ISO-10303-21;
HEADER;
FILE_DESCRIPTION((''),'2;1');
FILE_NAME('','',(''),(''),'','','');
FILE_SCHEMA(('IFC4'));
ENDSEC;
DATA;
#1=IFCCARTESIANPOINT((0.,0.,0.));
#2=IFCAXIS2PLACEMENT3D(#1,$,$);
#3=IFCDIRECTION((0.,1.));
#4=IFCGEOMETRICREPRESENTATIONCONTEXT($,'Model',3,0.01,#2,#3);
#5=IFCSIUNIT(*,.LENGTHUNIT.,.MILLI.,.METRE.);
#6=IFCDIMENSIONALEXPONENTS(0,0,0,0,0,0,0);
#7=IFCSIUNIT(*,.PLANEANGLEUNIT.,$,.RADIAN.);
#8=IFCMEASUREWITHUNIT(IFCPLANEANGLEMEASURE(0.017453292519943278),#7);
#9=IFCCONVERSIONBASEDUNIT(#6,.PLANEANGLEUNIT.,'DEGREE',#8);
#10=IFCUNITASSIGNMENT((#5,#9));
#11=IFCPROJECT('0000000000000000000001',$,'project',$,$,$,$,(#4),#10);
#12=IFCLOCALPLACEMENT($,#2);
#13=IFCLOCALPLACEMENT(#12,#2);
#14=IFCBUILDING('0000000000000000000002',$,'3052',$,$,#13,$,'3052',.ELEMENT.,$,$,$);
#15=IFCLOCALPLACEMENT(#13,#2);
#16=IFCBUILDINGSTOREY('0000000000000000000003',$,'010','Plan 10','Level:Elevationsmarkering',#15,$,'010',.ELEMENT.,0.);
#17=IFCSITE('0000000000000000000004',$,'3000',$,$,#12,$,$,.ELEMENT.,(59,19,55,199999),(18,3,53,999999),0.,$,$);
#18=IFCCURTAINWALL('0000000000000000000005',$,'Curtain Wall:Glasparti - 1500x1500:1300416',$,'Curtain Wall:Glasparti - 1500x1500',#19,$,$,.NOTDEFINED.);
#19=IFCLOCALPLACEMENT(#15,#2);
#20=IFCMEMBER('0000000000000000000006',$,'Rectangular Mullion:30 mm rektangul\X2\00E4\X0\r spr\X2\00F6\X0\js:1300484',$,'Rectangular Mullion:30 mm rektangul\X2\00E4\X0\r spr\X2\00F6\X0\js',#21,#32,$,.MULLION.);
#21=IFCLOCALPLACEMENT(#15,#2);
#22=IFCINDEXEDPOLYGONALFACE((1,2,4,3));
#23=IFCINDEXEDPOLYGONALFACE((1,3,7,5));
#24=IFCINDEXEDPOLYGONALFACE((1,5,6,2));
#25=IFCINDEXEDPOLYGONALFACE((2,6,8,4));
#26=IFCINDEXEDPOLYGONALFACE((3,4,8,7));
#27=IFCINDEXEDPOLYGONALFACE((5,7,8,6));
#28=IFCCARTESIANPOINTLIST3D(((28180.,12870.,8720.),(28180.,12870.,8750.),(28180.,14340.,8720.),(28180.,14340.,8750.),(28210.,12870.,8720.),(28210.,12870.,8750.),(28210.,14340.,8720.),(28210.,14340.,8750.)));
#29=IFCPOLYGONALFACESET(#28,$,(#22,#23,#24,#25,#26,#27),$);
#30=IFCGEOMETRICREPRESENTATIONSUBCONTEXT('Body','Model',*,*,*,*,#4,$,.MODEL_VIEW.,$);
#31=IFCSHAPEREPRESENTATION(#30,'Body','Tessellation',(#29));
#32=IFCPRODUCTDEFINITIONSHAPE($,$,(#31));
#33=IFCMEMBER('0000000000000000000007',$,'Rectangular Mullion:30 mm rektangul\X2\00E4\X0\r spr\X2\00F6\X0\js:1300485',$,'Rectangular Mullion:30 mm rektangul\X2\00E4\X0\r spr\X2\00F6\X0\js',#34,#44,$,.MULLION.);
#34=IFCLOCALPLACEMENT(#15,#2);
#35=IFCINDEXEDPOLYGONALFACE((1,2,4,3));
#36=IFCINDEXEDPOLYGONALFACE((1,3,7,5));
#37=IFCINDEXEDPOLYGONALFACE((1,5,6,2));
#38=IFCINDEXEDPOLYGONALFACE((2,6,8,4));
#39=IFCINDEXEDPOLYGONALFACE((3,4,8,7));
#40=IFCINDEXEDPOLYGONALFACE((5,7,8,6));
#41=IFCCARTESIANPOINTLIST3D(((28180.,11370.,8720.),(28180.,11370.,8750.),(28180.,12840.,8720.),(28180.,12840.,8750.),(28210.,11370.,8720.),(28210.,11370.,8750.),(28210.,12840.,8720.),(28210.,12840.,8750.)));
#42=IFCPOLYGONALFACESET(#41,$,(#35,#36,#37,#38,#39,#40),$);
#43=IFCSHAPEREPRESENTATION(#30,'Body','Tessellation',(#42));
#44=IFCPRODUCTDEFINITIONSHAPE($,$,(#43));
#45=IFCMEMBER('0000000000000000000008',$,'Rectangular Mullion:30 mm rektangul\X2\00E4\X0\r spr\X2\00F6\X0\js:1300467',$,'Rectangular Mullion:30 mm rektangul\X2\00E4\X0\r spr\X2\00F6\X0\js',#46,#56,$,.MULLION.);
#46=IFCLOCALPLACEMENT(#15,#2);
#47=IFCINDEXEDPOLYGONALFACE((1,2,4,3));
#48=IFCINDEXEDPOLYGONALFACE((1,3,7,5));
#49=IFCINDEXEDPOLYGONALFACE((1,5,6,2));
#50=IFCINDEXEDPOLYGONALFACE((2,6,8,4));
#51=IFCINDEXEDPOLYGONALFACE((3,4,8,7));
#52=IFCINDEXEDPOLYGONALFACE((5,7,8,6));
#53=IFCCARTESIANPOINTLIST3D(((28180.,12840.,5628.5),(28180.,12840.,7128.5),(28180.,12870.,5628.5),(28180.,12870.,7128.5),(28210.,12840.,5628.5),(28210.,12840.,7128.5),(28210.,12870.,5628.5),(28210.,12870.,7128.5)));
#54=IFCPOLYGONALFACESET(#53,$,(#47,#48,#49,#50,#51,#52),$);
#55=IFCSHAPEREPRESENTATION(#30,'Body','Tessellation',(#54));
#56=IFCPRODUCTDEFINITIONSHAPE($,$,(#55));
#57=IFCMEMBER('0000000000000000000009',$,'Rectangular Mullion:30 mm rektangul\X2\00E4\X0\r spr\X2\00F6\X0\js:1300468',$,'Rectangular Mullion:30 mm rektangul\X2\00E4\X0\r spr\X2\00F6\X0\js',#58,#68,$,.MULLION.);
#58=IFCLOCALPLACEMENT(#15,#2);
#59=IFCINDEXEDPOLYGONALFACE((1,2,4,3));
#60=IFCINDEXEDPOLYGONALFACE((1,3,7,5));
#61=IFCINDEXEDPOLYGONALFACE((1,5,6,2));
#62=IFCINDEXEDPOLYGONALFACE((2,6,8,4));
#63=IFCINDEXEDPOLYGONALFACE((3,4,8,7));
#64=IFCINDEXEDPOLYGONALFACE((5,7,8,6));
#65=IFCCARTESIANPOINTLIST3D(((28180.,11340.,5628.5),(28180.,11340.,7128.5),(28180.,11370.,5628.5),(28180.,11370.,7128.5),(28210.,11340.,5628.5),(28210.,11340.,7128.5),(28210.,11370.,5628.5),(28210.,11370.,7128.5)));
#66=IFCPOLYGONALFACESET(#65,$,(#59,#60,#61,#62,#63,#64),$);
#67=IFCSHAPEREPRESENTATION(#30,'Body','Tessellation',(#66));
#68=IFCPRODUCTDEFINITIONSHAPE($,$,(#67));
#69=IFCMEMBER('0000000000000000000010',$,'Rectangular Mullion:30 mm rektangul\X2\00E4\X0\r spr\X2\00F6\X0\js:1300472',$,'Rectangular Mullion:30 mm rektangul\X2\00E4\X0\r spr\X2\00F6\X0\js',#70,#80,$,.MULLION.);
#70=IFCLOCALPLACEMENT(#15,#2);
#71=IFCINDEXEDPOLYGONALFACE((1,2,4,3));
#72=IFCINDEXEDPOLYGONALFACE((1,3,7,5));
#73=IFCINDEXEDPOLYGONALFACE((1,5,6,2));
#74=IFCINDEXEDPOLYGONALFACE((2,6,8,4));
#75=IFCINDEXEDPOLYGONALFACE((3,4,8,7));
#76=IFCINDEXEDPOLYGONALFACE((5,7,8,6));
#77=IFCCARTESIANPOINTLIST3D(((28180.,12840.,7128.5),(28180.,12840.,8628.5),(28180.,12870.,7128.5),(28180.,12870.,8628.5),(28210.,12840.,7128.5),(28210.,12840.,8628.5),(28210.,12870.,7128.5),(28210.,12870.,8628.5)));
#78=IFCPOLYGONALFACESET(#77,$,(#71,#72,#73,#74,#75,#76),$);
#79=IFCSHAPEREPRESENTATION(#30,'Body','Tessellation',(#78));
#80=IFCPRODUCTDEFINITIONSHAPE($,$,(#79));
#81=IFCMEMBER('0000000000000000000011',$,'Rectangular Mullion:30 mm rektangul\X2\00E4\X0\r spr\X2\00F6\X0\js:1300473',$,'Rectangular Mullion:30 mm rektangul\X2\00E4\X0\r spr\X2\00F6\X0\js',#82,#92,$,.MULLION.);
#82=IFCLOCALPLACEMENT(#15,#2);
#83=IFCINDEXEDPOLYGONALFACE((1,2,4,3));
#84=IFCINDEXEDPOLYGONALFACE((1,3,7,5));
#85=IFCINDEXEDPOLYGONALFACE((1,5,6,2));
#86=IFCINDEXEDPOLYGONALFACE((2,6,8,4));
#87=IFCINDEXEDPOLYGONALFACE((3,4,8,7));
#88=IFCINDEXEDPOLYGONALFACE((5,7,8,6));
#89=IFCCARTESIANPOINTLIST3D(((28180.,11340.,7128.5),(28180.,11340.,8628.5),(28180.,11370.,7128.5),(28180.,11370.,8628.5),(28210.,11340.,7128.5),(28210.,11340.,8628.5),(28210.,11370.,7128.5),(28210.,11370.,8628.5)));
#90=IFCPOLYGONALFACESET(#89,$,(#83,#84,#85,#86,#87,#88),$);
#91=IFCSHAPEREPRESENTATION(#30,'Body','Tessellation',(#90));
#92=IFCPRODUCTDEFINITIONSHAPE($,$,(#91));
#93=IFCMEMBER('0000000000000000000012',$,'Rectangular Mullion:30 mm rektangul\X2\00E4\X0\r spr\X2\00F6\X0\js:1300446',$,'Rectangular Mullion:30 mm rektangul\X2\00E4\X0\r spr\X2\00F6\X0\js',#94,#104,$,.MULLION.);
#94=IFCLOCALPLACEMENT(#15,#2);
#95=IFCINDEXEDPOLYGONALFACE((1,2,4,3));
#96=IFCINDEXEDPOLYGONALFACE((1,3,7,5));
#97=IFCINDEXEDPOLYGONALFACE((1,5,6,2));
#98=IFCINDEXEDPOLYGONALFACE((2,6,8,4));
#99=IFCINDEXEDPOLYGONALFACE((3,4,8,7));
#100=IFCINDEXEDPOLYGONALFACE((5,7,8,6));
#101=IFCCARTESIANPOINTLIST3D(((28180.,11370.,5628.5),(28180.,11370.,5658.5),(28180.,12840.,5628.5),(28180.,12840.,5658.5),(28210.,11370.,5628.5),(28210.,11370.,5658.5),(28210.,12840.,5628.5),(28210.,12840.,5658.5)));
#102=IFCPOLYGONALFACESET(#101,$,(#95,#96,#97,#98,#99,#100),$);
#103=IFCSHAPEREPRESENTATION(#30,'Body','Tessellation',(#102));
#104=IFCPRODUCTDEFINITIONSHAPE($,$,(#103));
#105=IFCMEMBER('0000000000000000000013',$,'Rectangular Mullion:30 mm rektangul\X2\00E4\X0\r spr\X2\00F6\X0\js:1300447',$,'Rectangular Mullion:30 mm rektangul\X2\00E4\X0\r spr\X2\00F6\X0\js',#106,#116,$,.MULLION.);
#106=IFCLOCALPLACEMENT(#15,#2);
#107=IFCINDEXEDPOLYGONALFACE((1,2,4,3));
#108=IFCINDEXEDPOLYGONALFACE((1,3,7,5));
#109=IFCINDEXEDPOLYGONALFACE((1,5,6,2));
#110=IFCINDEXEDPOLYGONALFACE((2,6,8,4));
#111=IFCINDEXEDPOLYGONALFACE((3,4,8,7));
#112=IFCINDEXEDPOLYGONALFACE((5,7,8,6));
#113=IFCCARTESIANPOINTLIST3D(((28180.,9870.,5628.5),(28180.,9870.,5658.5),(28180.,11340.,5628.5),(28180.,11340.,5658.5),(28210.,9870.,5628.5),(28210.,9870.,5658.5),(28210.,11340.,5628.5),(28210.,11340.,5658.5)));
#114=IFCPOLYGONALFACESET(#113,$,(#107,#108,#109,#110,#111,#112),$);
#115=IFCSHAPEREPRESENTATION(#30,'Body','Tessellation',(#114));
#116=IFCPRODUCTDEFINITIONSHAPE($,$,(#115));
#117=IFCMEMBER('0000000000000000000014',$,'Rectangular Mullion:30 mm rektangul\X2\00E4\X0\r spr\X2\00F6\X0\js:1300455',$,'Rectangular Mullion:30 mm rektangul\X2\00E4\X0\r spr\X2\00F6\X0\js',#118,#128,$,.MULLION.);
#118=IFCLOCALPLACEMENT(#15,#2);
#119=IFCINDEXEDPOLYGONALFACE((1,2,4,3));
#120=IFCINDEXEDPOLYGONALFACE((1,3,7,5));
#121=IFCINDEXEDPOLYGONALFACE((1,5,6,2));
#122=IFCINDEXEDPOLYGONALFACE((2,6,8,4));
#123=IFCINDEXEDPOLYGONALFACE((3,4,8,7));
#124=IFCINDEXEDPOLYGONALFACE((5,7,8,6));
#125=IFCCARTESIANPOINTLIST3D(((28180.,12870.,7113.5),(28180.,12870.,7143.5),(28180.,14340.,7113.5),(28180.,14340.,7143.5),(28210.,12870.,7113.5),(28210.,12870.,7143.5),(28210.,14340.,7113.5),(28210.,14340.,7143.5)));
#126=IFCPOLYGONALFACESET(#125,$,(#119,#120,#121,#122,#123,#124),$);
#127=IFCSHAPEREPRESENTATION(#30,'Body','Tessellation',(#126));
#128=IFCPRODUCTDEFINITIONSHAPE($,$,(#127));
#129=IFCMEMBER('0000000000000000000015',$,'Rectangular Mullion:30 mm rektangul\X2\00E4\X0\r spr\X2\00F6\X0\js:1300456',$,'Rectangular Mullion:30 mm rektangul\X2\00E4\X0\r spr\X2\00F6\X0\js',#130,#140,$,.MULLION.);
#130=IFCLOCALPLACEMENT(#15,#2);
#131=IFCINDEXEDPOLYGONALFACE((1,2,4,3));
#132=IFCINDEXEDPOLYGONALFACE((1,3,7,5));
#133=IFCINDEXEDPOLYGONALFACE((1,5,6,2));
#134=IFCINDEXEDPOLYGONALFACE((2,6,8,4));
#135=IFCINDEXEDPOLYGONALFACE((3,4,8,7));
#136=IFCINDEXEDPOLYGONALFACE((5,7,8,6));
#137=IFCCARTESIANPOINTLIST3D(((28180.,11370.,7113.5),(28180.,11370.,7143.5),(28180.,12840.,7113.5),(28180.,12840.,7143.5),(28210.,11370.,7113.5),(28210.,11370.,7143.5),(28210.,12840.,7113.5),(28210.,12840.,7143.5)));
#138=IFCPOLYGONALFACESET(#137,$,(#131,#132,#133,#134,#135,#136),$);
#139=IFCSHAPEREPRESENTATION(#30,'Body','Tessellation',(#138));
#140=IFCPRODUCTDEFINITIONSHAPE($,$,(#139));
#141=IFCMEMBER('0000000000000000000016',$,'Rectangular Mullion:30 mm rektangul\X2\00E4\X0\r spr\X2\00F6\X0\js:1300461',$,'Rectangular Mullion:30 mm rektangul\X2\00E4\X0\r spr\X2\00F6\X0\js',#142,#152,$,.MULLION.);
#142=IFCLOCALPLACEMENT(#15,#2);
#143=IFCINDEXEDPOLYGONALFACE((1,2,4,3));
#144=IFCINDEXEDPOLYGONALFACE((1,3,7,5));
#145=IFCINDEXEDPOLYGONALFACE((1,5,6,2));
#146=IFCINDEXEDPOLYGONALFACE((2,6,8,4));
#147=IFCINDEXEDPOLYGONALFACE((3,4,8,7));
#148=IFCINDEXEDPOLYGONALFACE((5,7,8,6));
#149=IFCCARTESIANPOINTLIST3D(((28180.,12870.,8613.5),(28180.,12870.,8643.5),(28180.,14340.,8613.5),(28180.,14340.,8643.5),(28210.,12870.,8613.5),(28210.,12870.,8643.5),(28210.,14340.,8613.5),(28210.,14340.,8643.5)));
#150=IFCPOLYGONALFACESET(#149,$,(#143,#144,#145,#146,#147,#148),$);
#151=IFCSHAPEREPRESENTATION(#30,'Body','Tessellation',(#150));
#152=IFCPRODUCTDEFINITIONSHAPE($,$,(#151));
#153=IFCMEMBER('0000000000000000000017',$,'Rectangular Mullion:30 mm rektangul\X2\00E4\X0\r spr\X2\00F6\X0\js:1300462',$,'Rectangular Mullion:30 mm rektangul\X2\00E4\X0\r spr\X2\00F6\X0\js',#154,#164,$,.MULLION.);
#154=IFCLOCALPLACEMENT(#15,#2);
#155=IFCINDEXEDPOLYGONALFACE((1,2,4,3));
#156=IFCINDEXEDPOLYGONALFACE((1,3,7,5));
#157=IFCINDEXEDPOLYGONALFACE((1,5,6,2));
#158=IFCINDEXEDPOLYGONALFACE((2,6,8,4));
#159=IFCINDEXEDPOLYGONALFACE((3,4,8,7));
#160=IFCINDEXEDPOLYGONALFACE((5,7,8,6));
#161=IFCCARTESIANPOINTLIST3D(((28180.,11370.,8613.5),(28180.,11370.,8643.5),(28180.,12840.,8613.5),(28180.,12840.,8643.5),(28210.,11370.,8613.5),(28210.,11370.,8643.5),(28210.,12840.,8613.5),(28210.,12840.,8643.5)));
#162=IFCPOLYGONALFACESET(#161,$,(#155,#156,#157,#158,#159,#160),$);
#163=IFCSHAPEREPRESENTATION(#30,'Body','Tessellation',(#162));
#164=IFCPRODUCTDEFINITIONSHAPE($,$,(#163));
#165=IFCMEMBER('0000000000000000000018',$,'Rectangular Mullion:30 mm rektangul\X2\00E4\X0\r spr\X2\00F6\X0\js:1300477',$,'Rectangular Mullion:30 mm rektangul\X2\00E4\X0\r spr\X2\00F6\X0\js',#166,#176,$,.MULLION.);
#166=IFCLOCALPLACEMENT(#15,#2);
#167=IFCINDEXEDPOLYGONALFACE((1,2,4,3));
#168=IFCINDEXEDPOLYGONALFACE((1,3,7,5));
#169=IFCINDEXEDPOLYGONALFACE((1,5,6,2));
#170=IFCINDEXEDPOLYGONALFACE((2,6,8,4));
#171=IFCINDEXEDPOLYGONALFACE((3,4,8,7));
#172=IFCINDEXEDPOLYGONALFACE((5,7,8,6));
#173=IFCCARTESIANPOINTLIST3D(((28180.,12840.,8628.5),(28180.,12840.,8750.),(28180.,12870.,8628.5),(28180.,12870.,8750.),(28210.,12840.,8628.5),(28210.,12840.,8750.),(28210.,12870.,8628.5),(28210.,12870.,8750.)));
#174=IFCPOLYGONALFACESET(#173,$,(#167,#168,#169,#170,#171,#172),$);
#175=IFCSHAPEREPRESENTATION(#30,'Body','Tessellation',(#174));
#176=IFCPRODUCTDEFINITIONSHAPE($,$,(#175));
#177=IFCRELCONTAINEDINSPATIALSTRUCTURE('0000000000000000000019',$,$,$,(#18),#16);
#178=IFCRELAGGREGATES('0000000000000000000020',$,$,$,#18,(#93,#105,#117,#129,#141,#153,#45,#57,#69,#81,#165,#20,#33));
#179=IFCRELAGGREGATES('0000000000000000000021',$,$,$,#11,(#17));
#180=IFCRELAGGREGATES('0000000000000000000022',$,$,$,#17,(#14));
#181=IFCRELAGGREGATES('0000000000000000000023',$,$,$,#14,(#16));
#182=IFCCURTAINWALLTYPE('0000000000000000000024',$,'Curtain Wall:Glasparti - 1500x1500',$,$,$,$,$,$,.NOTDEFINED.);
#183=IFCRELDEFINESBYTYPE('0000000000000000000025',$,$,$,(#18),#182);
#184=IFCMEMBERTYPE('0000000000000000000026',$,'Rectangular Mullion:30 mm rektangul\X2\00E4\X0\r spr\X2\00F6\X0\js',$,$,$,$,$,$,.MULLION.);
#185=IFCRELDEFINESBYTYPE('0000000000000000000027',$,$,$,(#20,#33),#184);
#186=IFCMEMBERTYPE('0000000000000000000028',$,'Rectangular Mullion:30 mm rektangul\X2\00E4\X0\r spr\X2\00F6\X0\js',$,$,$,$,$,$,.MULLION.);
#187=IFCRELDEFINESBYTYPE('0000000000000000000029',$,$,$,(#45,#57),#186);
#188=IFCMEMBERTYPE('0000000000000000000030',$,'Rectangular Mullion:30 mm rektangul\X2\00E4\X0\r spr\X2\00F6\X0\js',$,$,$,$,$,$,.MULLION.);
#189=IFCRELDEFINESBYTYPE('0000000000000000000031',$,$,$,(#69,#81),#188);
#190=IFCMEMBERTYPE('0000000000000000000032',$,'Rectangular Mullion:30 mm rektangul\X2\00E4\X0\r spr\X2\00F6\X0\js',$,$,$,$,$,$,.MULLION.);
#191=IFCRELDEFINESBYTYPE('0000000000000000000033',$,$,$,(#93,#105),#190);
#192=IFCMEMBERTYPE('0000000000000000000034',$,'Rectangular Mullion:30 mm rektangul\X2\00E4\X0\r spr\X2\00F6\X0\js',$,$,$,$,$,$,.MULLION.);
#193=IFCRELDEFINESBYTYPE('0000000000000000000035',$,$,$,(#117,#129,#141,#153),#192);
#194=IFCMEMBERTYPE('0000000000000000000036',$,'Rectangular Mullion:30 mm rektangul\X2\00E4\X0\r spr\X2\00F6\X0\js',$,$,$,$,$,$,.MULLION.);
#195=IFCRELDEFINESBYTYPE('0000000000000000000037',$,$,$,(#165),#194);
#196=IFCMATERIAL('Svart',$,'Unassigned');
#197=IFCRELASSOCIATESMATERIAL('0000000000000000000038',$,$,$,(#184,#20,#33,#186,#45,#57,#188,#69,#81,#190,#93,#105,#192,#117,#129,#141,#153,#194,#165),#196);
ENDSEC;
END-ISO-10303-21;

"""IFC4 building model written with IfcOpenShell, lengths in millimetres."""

from ifc_helpers import new_model, entity, si_unit, converted_unit, direction, frame, origin, place, context, subcontext, project, spatial, indexed_curve, outline, extrude, source, transform, mapped, material, type_object, type_shapes, element, aggregate, save


model = new_model("IFC4")

# Units and contexts
model_context = context("Model", 3, precision=0.01, world=origin(), true_north=direction((0.0, 1.0)))
body_context = subcontext(model_context, "Body", "Model", "MODEL_VIEW")
ifc_project = project(units=[si_unit("LENGTHUNIT", "METRE", prefix="MILLI"), converted_unit("PLANEANGLEUNIT", "DEGREE", entity("IfcPlaneAngleMeasure", 0.017453292519943278), si_unit("PLANEANGLEUNIT", "RADIAN"), dimensions=[0, 0, 0, 0, 0, 0, 0])], contexts=[model_context])

# Site, building, storey
site_placement = place(None, origin())
site = spatial("IfcSite", under=ifc_project, at=site_placement, Name="3000", CompositionType="ELEMENT", RefLatitude=(59, 19, 55, 199999), RefLongitude=(18, 3, 53, 999999), RefElevation=0.0)
building_placement = place(site_placement, origin())
building = spatial("IfcBuilding", under=site, at=building_placement, Name="3052", LongName="3052", CompositionType="ELEMENT")
storey_placement = place(building_placement, origin())
storey = spatial("IfcBuildingStorey", under=building, at=storey_placement, Name="010", Description="Plan 10", ObjectType="Level:Elevationsmarkering", LongName="010", CompositionType="ELEMENT", Elevation=0.0)

# Curtain wall, members
curtain_wall_type = type_object("IfcCurtainWallType", Name="Curtain Wall:Glasparti - 1500x1500", PredefinedType="NOTDEFINED")
curtain_wall_placement = place(storey_placement, origin())
curtain_wall = element("IfcCurtainWall", 1, at=curtain_wall_placement, inside=storey, type_object=curtain_wall_type, Name="Curtain Wall:Glasparti - 1500x1500:1300416", ObjectType="Curtain Wall:Glasparti - 1500x1500", PredefinedType="NOTDEFINED")
ifc_material_1 = material(Name="Svart", Category="Unassigned")
member_type_1 = type_object("IfcMemberType", Name="Rectangular Mullion:30 mm rektangulär spröjs", PredefinedType="MULLION", material=ifc_material_1)
shared_shape_1 = source(origin(), body_context, "Body", "SweptSolid", [
    extrude(outline(indexed_curve([(-15.0, -15.0), (15.0, -15.0), (15.0, 15.0), (-15.0, 15.0), (-15.0, -15.0)], self_intersect=False)), frame((-15.0, 0.0, -1470.0), z_axis=(0.0, 0.0, 1.0), x_axis=(-1.0, 0.0, 0.0)), (0.0, 0.0, 1.0), 1470.0),
])
type_shapes(member_type_1, [shared_shape_1])
member_1_placement = place(curtain_wall_placement, frame((28195.0, 12870.0, 8750.0), z_axis=(0.0, -1.0, 0.0), x_axis=(0.0, 0.0, 1.0)))
member_1 = element("IfcMember", 2, at=member_1_placement, type_object=member_type_1, material=ifc_material_1, Name="Rectangular Mullion:30 mm rektangulär spröjs:1300484", ObjectType="Rectangular Mullion:30 mm rektangulär spröjs", PredefinedType="MULLION", context=body_context, shape_type="MappedRepresentation", body=[
    mapped(shared_shape_1, transform((0.0, 0.0, 0.0), scale=1.0)),
])
member_2_placement = place(curtain_wall_placement, frame((28195.0, 11370.0, 8750.0), z_axis=(0.0, -1.0, 0.0), x_axis=(0.0, 0.0, 1.0)))
member_2 = element("IfcMember", 3, at=member_2_placement, type_object=member_type_1, material=ifc_material_1, Name="Rectangular Mullion:30 mm rektangulär spröjs:1300485", ObjectType="Rectangular Mullion:30 mm rektangulär spröjs", PredefinedType="MULLION", context=body_context, shape_type="MappedRepresentation", body=[
    mapped(shared_shape_1, transform((0.0, 0.0, 0.0), scale=1.0)),
])
member_type_2 = type_object("IfcMemberType", Name="Rectangular Mullion:30 mm rektangulär spröjs", PredefinedType="MULLION", material=ifc_material_1)
shared_shape_2 = source(origin(), body_context, "Body", "SweptSolid", [
    extrude(outline(indexed_curve([(-15.0, -15.0), (15.0, -15.0), (15.0, 15.0), (-15.0, 15.0), (-15.0, -15.0)], self_intersect=False)), frame((0.0, 0.0, -1500.0), z_axis=(0.0, 0.0, 1.0), x_axis=(-1.0, 0.0, 0.0)), (0.0, 0.0, 1.0), 1500.0),
])
type_shapes(member_type_2, [shared_shape_2])
member_3_placement = place(curtain_wall_placement, frame((28195.0, 12855.0, 5628.5), z_axis=(0.0, 0.0, -1.0), x_axis=(0.0, -1.0, 0.0)))
member_3 = element("IfcMember", 4, at=member_3_placement, type_object=member_type_2, material=ifc_material_1, Name="Rectangular Mullion:30 mm rektangulär spröjs:1300467", ObjectType="Rectangular Mullion:30 mm rektangulär spröjs", PredefinedType="MULLION", context=body_context, shape_type="MappedRepresentation", body=[
    mapped(shared_shape_2, transform((0.0, 0.0, 0.0), scale=1.0)),
])
member_4_placement = place(curtain_wall_placement, frame((28195.0, 11355.0, 5628.5), z_axis=(0.0, 0.0, -1.0), x_axis=(0.0, -1.0, 0.0)))
member_4 = element("IfcMember", 5, at=member_4_placement, type_object=member_type_2, material=ifc_material_1, Name="Rectangular Mullion:30 mm rektangulär spröjs:1300468", ObjectType="Rectangular Mullion:30 mm rektangulär spröjs", PredefinedType="MULLION", context=body_context, shape_type="MappedRepresentation", body=[
    mapped(shared_shape_2, transform((0.0, 0.0, 0.0), scale=1.0)),
])
member_type_3 = type_object("IfcMemberType", Name="Rectangular Mullion:30 mm rektangulär spröjs", PredefinedType="MULLION", material=ifc_material_1)
shared_shape_3 = source(origin(), body_context, "Body", "SweptSolid", [
    extrude(outline(indexed_curve([(-15.0, -15.0), (15.0, -15.0), (15.0, 15.0), (-15.0, 15.0), (-15.0, -15.0)], self_intersect=False)), frame((0.0, 0.0, -1500.0), z_axis=(0.0, 0.0, 1.0), x_axis=(-1.0, 0.0, 0.0)), (0.0, 0.0, 1.0), 1500.0),
])
type_shapes(member_type_3, [shared_shape_3])
member_5_placement = place(curtain_wall_placement, frame((28195.0, 12855.0, 7128.5), z_axis=(0.0, 0.0, -1.0), x_axis=(0.0, -1.0, 0.0)))
member_5 = element("IfcMember", 6, at=member_5_placement, type_object=member_type_3, material=ifc_material_1, Name="Rectangular Mullion:30 mm rektangulär spröjs:1300472", ObjectType="Rectangular Mullion:30 mm rektangulär spröjs", PredefinedType="MULLION", context=body_context, shape_type="MappedRepresentation", body=[
    mapped(shared_shape_3, transform((0.0, 0.0, 0.0), scale=1.0)),
])
member_6_placement = place(curtain_wall_placement, frame((28195.0, 11355.0, 7128.5), z_axis=(0.0, 0.0, -1.0), x_axis=(0.0, -1.0, 0.0)))
member_6 = element("IfcMember", 7, at=member_6_placement, type_object=member_type_3, material=ifc_material_1, Name="Rectangular Mullion:30 mm rektangulär spröjs:1300473", ObjectType="Rectangular Mullion:30 mm rektangulär spröjs", PredefinedType="MULLION", context=body_context, shape_type="MappedRepresentation", body=[
    mapped(shared_shape_3, transform((0.0, 0.0, 0.0), scale=1.0)),
])
member_type_4 = type_object("IfcMemberType", Name="Rectangular Mullion:30 mm rektangulär spröjs", PredefinedType="MULLION", material=ifc_material_1)
shared_shape_4 = source(origin(), body_context, "Body", "SweptSolid", [
    extrude(outline(indexed_curve([(-15.0, -15.0), (15.0, -15.0), (15.0, 15.0), (-15.0, 15.0), (-15.0, -15.0)], self_intersect=False)), frame((-15.0, 0.0, -1470.0), z_axis=(0.0, 0.0, 1.0), x_axis=(-1.0, 0.0, 0.0)), (0.0, 0.0, 1.0), 1470.0),
])
type_shapes(member_type_4, [shared_shape_4])
member_7_placement = place(curtain_wall_placement, frame((28195.0, 12840.0, 5628.5), z_axis=(0.0, 1.0, 0.0), x_axis=(0.0, 0.0, -1.0)))
member_7 = element("IfcMember", 8, at=member_7_placement, type_object=member_type_4, material=ifc_material_1, Name="Rectangular Mullion:30 mm rektangulär spröjs:1300446", ObjectType="Rectangular Mullion:30 mm rektangulär spröjs", PredefinedType="MULLION", context=body_context, shape_type="MappedRepresentation", body=[
    mapped(shared_shape_4, transform((0.0, 0.0, 0.0), scale=1.0)),
])
member_8_placement = place(curtain_wall_placement, frame((28195.0, 11340.0, 5628.5), z_axis=(0.0, 1.0, 0.0), x_axis=(0.0, 0.0, -1.0)))
member_8 = element("IfcMember", 9, at=member_8_placement, type_object=member_type_4, material=ifc_material_1, Name="Rectangular Mullion:30 mm rektangulär spröjs:1300447", ObjectType="Rectangular Mullion:30 mm rektangulär spröjs", PredefinedType="MULLION", context=body_context, shape_type="MappedRepresentation", body=[
    mapped(shared_shape_4, transform((0.0, 0.0, 0.0), scale=1.0)),
])
member_type_5 = type_object("IfcMemberType", Name="Rectangular Mullion:30 mm rektangulär spröjs", PredefinedType="MULLION", material=ifc_material_1)
shared_shape_5 = source(origin(), body_context, "Body", "SweptSolid", [
    extrude(outline(indexed_curve([(-15.0, -15.0), (15.0, -15.0), (15.0, 15.0), (-15.0, 15.0), (-15.0, -15.0)], self_intersect=False)), frame((0.0, 0.0, -1470.0), z_axis=(0.0, 0.0, 1.0), x_axis=(-1.0, 0.0, 0.0)), (0.0, 0.0, 1.0), 1470.0),
])
type_shapes(member_type_5, [shared_shape_5])
member_9_placement = place(curtain_wall_placement, frame((28195.0, 12870.0, 7128.5), z_axis=(0.0, -1.0, 0.0), x_axis=(0.0, 0.0, 1.0)))
member_9 = element("IfcMember", 10, at=member_9_placement, type_object=member_type_5, material=ifc_material_1, Name="Rectangular Mullion:30 mm rektangulär spröjs:1300455", ObjectType="Rectangular Mullion:30 mm rektangulär spröjs", PredefinedType="MULLION", context=body_context, shape_type="MappedRepresentation", body=[
    mapped(shared_shape_5, transform((0.0, 0.0, 0.0), scale=1.0)),
])
member_10_placement = place(curtain_wall_placement, frame((28195.0, 11370.0, 7128.5), z_axis=(0.0, -1.0, 0.0), x_axis=(0.0, 0.0, 1.0)))
member_10 = element("IfcMember", 11, at=member_10_placement, type_object=member_type_5, material=ifc_material_1, Name="Rectangular Mullion:30 mm rektangulär spröjs:1300456", ObjectType="Rectangular Mullion:30 mm rektangulär spröjs", PredefinedType="MULLION", context=body_context, shape_type="MappedRepresentation", body=[
    mapped(shared_shape_5, transform((0.0, 0.0, 0.0), scale=1.0)),
])
member_11_placement = place(curtain_wall_placement, frame((28195.0, 12870.0, 8628.5), z_axis=(0.0, -1.0, 0.0), x_axis=(0.0, 0.0, 1.0)))
member_11 = element("IfcMember", 12, at=member_11_placement, type_object=member_type_5, material=ifc_material_1, Name="Rectangular Mullion:30 mm rektangulär spröjs:1300461", ObjectType="Rectangular Mullion:30 mm rektangulär spröjs", PredefinedType="MULLION", context=body_context, shape_type="MappedRepresentation", body=[
    mapped(shared_shape_5, transform((0.0, 0.0, 0.0), scale=1.0)),
])
member_12_placement = place(curtain_wall_placement, frame((28195.0, 11370.0, 8628.5), z_axis=(0.0, -1.0, 0.0), x_axis=(0.0, 0.0, 1.0)))
member_12 = element("IfcMember", 13, at=member_12_placement, type_object=member_type_5, material=ifc_material_1, Name="Rectangular Mullion:30 mm rektangulär spröjs:1300462", ObjectType="Rectangular Mullion:30 mm rektangulär spröjs", PredefinedType="MULLION", context=body_context, shape_type="MappedRepresentation", body=[
    mapped(shared_shape_5, transform((0.0, 0.0, 0.0), scale=1.0)),
])
member_type_6 = type_object("IfcMemberType", Name="Rectangular Mullion:30 mm rektangulär spröjs", PredefinedType="MULLION", material=ifc_material_1)
shared_shape_6 = source(origin(), body_context, "Body", "SweptSolid", [
    extrude(outline(indexed_curve([(-15.0, -15.0), (15.0, -15.0), (15.0, 15.0), (-15.0, 15.0), (-15.0, -15.0)], self_intersect=False)), frame((0.0, 0.0, -121.5), z_axis=(0.0, 0.0, 1.0), x_axis=(-1.0, 0.0, 0.0)), (0.0, 0.0, 1.0), 121.5),
])
type_shapes(member_type_6, [shared_shape_6])
member_13_placement = place(curtain_wall_placement, frame((28195.0, 12855.0, 8628.5), z_axis=(0.0, 0.0, -1.0), x_axis=(0.0, -1.0, 0.0)))
member_13 = element("IfcMember", 14, at=member_13_placement, type_object=member_type_6, material=ifc_material_1, Name="Rectangular Mullion:30 mm rektangulär spröjs:1300477", ObjectType="Rectangular Mullion:30 mm rektangulär spröjs", PredefinedType="MULLION", context=body_context, shape_type="MappedRepresentation", body=[
    mapped(shared_shape_6, transform((0.0, 0.0, 0.0), scale=1.0)),
])
aggregate(curtain_wall, [member_7, member_8, member_9, member_10, member_11, member_12, member_3, member_4, member_5, member_6, member_13, member_1, member_2])

save(model, "model.ifc")
